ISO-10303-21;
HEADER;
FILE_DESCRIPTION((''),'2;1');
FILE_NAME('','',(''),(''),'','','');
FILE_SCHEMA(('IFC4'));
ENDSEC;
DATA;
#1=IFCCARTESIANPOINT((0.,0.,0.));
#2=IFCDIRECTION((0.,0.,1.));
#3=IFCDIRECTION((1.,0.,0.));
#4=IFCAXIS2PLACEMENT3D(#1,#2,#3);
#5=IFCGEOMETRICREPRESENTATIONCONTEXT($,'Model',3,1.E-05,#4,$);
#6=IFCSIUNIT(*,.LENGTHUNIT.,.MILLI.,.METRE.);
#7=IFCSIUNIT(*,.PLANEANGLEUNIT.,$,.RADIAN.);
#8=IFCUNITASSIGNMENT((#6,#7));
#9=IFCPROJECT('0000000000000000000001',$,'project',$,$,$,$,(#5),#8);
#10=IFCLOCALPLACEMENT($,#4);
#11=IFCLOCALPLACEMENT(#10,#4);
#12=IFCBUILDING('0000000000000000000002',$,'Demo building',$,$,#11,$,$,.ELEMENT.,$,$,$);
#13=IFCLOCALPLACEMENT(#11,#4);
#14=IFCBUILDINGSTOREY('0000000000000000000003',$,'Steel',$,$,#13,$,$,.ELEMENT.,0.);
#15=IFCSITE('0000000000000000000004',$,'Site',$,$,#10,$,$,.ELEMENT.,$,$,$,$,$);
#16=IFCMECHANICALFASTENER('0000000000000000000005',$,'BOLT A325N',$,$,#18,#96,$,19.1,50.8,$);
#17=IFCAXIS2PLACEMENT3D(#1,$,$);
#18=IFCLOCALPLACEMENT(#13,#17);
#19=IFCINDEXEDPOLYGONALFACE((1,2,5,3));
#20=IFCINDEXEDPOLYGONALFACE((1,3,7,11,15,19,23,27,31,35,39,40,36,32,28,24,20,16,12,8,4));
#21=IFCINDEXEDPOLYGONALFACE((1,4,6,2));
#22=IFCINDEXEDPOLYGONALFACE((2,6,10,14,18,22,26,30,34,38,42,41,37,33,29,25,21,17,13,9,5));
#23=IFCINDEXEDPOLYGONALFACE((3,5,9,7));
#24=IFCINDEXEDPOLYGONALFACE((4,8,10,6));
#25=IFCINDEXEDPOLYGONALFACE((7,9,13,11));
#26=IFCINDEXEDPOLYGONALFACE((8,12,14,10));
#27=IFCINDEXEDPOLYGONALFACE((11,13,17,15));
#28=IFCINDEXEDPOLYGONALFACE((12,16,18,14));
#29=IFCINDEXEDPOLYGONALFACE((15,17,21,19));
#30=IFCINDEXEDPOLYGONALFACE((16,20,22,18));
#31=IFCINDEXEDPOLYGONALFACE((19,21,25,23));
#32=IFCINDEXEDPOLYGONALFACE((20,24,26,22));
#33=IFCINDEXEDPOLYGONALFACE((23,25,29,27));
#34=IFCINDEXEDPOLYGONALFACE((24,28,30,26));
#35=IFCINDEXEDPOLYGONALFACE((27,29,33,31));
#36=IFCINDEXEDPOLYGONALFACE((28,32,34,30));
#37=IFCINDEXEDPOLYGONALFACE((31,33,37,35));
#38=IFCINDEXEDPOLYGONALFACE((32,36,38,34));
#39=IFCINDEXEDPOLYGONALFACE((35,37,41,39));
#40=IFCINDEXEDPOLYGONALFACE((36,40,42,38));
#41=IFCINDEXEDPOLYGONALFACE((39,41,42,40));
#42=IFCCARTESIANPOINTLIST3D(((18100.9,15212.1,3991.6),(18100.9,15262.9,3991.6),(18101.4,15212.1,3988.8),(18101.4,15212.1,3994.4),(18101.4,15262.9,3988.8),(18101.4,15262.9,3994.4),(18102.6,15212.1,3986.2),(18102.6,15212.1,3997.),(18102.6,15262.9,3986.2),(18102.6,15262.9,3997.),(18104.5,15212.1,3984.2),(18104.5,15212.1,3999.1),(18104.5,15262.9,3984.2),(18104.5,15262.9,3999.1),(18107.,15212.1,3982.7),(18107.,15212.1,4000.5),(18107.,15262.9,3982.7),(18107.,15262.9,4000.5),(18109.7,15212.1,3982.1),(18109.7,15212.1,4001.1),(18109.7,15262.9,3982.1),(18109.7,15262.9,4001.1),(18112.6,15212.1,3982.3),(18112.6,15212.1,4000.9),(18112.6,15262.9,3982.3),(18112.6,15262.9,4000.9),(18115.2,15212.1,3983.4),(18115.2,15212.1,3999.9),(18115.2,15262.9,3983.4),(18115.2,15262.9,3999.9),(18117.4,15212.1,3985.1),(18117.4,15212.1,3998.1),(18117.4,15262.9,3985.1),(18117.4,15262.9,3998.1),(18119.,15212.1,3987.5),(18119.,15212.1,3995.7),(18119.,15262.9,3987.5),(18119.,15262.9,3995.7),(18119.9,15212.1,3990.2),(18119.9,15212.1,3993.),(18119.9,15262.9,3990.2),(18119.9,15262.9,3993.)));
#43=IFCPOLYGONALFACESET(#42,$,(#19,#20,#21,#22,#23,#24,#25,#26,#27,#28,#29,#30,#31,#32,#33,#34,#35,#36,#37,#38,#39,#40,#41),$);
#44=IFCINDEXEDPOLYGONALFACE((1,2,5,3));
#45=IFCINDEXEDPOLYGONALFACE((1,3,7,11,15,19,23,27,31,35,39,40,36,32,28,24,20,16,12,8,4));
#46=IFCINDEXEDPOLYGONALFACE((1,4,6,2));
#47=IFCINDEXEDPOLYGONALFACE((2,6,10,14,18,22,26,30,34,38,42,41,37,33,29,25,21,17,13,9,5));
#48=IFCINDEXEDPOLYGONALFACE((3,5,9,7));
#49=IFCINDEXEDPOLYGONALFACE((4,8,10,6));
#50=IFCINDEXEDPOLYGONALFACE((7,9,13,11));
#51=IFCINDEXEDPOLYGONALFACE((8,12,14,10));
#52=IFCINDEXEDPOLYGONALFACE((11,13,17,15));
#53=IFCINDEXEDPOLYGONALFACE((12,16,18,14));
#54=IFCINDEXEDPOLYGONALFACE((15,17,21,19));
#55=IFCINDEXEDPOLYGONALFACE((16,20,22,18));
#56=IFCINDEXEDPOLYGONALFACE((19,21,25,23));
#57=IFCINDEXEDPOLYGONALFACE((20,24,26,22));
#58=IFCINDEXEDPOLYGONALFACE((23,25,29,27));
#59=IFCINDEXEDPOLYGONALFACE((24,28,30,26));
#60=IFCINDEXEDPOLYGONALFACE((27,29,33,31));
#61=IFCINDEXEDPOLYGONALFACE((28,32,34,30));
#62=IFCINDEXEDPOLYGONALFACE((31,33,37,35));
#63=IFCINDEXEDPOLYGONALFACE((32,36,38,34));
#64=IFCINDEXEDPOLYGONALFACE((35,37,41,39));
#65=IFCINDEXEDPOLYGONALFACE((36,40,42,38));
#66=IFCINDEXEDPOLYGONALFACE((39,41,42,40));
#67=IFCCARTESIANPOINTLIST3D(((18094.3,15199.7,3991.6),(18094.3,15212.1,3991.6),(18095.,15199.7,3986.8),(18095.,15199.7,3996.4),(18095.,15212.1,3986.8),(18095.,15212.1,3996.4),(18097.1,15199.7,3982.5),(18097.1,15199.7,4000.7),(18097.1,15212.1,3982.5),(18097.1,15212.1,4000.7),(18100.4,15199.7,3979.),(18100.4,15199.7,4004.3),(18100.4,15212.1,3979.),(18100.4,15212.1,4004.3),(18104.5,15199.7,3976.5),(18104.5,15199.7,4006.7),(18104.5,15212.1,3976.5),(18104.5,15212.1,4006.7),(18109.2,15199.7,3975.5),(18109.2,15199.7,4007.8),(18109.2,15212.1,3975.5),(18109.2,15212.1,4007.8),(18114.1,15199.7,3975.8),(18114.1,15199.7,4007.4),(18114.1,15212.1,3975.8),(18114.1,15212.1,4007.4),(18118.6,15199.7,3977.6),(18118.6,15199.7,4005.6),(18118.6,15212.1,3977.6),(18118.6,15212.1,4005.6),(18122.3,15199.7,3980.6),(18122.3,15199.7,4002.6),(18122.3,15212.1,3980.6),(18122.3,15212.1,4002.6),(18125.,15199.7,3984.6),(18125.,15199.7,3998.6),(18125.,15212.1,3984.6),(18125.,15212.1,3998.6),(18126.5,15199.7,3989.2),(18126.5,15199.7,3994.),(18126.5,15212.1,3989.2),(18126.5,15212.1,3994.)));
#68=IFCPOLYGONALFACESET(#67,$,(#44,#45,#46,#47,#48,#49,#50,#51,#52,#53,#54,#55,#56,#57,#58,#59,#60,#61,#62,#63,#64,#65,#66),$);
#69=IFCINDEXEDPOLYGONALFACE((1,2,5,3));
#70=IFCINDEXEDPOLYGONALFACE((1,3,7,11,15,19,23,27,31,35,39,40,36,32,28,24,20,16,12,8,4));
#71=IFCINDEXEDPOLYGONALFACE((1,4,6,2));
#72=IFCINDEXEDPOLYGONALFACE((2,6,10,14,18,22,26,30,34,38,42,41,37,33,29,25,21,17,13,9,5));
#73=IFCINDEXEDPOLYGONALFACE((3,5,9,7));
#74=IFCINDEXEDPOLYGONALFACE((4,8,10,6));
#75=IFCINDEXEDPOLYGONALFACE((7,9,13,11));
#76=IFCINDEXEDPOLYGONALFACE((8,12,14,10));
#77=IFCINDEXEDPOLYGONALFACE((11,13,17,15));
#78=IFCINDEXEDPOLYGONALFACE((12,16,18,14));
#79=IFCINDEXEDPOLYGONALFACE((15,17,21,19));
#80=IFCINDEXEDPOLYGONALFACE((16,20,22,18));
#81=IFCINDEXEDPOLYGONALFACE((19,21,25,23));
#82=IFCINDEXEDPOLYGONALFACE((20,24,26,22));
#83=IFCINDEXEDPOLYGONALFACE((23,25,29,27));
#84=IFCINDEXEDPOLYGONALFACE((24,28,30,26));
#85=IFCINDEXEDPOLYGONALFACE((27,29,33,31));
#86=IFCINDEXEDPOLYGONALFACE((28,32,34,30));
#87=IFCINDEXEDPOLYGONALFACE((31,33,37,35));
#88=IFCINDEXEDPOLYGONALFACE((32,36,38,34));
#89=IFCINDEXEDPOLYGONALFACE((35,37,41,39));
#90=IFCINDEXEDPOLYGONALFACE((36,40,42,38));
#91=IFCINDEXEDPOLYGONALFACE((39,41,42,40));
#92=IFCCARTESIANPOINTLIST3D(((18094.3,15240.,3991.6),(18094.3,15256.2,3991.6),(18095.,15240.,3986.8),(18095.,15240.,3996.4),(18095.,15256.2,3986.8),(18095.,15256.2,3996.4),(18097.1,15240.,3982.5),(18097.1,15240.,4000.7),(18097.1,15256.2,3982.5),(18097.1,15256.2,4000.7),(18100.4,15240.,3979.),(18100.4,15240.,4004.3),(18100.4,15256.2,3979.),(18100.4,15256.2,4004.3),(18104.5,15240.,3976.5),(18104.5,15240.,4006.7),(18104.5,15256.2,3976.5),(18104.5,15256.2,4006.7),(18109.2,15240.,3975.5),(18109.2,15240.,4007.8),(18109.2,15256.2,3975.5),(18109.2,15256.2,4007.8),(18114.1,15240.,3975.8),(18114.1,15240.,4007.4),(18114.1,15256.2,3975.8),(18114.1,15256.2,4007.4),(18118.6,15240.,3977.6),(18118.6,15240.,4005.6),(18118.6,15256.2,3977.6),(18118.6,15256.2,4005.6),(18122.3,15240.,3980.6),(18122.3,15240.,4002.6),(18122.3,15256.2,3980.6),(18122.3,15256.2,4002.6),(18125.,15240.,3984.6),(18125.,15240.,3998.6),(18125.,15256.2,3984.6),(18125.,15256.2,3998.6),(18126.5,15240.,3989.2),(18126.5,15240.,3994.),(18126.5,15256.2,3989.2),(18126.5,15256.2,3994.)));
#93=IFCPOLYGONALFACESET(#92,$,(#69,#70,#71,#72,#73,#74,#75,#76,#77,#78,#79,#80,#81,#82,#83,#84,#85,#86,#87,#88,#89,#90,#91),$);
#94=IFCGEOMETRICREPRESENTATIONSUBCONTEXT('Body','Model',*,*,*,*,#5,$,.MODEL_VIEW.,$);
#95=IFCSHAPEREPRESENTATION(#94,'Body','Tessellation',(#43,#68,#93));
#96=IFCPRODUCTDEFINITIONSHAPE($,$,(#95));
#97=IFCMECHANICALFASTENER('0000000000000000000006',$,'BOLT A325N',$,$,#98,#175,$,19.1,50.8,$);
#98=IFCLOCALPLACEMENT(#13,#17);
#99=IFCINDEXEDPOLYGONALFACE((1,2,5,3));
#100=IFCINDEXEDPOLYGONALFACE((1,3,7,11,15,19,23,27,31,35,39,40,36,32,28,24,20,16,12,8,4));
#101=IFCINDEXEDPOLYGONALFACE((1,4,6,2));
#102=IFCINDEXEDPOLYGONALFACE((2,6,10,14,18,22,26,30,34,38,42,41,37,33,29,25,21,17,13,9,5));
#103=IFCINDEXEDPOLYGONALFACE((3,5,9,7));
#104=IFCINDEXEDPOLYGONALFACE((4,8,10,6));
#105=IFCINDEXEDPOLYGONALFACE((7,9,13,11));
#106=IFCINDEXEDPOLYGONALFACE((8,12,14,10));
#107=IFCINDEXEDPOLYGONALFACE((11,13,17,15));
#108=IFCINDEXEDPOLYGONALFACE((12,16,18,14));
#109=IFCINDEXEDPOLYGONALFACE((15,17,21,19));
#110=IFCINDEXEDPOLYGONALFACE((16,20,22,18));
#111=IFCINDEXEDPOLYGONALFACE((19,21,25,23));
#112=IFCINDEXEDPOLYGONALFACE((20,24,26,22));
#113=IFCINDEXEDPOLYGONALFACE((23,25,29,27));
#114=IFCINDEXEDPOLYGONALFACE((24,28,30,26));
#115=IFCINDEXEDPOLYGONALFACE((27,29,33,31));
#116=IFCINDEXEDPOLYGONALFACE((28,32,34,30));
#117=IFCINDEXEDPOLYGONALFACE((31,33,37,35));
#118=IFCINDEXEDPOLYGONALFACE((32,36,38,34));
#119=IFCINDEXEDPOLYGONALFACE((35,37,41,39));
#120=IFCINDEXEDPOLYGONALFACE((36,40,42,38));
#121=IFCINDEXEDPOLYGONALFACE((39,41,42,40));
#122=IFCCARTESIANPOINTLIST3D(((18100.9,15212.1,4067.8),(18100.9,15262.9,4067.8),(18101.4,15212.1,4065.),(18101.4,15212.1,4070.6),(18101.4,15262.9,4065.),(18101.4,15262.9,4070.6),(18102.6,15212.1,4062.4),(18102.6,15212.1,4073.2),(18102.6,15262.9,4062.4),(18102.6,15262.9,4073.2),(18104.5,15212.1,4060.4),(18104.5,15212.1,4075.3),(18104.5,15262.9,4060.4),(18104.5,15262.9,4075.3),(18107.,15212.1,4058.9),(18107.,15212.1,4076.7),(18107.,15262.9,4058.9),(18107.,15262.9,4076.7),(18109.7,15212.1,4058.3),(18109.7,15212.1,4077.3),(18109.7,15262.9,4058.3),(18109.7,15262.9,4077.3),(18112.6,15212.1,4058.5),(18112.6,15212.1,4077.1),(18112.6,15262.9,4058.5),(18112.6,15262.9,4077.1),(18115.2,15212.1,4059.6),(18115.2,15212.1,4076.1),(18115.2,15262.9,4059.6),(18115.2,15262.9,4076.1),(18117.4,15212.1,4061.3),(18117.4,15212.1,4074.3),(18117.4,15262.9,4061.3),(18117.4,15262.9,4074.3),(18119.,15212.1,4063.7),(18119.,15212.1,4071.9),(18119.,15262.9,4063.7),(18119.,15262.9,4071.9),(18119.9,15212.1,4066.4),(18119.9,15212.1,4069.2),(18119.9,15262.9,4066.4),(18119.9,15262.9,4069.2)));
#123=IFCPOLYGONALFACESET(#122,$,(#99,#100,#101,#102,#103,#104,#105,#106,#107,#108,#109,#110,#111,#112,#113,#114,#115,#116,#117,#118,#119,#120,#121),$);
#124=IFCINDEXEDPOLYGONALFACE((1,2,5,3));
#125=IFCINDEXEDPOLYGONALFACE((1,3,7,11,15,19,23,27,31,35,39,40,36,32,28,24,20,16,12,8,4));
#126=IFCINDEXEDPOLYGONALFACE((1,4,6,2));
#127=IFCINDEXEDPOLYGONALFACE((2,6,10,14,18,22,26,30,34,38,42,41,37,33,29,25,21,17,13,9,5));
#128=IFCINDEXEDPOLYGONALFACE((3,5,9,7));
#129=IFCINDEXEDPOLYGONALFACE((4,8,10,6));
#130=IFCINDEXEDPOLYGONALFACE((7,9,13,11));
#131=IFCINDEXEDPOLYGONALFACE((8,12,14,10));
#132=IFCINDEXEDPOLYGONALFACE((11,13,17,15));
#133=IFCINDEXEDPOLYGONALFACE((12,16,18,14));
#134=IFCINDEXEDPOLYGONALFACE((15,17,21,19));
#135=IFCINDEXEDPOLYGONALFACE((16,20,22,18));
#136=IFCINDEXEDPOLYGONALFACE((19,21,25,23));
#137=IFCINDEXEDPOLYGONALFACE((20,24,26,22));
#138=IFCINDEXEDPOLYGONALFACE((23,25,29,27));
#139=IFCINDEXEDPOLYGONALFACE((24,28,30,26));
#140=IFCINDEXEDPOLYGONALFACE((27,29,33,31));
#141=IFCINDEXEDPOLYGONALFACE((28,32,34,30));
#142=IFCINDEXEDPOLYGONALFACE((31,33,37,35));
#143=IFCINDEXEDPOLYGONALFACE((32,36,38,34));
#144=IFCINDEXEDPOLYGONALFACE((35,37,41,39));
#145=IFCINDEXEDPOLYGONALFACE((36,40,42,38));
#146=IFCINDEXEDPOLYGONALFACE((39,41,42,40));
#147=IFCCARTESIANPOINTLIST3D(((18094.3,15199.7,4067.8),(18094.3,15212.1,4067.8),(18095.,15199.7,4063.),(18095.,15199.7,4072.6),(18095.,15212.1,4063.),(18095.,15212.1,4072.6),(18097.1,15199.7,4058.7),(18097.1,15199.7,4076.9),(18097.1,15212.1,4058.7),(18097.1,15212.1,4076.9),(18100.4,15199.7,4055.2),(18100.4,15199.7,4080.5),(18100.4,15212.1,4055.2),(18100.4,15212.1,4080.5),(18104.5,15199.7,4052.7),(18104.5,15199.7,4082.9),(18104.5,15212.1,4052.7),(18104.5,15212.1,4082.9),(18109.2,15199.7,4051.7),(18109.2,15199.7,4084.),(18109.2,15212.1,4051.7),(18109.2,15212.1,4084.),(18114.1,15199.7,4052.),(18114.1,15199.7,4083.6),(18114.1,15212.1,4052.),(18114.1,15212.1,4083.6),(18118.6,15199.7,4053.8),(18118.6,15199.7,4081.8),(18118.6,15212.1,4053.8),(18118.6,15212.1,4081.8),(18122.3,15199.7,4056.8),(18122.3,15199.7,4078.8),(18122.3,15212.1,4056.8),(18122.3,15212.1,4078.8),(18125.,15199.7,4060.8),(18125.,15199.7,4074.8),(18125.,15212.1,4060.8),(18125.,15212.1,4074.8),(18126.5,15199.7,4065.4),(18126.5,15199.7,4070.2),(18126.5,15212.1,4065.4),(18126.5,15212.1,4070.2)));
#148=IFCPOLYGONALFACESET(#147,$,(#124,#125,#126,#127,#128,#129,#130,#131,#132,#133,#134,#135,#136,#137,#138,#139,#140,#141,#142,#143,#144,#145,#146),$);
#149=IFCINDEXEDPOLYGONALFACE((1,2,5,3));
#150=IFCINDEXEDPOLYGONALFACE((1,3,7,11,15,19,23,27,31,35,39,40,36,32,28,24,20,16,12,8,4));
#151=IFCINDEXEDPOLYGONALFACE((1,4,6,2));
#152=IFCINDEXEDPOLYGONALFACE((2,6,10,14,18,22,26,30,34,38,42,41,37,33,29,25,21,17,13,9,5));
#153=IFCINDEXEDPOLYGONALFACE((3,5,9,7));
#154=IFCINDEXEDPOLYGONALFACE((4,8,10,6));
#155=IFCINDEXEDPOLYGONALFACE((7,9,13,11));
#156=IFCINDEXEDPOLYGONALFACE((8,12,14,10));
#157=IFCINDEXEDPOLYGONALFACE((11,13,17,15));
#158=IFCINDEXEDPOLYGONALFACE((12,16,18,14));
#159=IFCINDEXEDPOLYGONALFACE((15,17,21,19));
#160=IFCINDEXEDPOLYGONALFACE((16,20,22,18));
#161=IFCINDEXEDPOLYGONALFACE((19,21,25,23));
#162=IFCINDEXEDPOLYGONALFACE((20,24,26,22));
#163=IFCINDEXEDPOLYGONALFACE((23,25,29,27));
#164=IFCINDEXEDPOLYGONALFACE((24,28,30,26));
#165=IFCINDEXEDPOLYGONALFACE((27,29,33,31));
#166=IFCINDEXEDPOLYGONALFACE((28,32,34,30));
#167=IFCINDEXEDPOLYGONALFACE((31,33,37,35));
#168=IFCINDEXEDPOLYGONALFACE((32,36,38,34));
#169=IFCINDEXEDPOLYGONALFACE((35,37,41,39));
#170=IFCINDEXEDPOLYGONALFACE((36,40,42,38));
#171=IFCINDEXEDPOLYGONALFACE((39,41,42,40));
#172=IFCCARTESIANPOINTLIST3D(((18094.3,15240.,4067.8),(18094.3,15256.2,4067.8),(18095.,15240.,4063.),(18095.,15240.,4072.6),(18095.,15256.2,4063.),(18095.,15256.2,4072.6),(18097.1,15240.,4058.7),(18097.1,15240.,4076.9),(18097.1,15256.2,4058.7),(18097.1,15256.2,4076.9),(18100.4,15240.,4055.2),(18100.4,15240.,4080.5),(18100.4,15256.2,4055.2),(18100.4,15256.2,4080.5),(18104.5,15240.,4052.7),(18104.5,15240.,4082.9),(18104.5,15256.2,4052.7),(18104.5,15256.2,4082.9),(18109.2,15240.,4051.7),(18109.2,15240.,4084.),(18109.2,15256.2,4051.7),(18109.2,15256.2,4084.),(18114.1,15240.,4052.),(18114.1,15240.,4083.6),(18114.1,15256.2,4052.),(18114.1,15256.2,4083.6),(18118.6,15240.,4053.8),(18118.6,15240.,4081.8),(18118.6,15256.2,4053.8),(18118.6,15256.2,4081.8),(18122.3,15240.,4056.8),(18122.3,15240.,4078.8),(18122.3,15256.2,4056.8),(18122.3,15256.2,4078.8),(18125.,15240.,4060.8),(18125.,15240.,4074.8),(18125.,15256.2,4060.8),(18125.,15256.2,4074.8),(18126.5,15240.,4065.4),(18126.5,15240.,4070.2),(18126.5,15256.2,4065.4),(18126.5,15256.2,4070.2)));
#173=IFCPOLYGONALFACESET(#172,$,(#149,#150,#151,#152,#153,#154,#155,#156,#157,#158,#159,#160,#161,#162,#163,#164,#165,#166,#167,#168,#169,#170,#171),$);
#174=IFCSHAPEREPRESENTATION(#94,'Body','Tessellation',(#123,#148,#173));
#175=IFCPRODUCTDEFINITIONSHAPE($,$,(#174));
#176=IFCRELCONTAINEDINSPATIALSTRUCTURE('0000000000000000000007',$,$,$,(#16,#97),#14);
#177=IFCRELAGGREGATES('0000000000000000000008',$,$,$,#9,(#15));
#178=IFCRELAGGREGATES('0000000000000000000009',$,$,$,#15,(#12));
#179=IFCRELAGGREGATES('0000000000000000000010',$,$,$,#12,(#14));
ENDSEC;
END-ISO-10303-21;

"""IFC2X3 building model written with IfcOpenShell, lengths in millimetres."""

from ifc_helpers import new_model, si_unit, frame, origin, origin_with_axes, origin_2d, place, context, subcontext, project, spatial, circle, extrude, element, save


model = new_model("IFC2X3")

# Units and contexts
model_context = context("Model", 3, precision=1e-05, world=origin_with_axes())
body_context = subcontext(model_context, "Body", "Model", "MODEL_VIEW")
ifc_project = project(units=[si_unit("LENGTHUNIT", "METRE", prefix="MILLI"), si_unit("PLANEANGLEUNIT", "RADIAN")], contexts=[model_context])

# Site, building, storey
site_placement = place(None, origin_with_axes())
site = spatial("IfcSite", under=ifc_project, at=site_placement, Name="Site", CompositionType="ELEMENT")
building_placement = place(site_placement, origin_with_axes())
building = spatial("IfcBuilding", under=site, at=building_placement, Name="Demo building", CompositionType="ELEMENT")
placement = place(building_placement, origin_with_axes())
storey = spatial("IfcBuildingStorey", under=building, at=placement, Name="Steel", CompositionType="ELEMENT", Elevation=0.0)

# Mechanical fasteners
for number, where, z_axis, x_axis, name in (
    (1, (18110.5, 15212.1, 3991.6), (0.0, 1.0, 0.0), (-1.0, 0.0, 0.0), "BOLT A325N"),
    (2, (18110.5, 15212.1, 4067.8), (0.0, 1.0, 0.0), (-1.0, 0.0, 0.0), "BOLT A325N"),
):
    element("IfcMechanicalFastener", number, at=place(placement, frame(where, z_axis=z_axis, x_axis=x_axis)), inside=storey, Name=name, NominalDiameter=19.1, NominalLength=50.8, context=body_context, shape_type="SweptSolid", body=[
        extrude(circle(Radius=9.5, at=origin_2d()), origin(), (0.0, 0.0, 1.0), 50.8),
        extrude(circle(Radius=16.2, at=origin_2d()), frame((0.0, 0.0, -12.4)), (0.0, 0.0, 1.0), 12.4),
        extrude(circle(Radius=16.2, at=origin_2d()), frame((0.0, 0.0, 27.9)), (0.0, 0.0, 1.0), 16.2),
    ])

save(model, "model.ifc")
